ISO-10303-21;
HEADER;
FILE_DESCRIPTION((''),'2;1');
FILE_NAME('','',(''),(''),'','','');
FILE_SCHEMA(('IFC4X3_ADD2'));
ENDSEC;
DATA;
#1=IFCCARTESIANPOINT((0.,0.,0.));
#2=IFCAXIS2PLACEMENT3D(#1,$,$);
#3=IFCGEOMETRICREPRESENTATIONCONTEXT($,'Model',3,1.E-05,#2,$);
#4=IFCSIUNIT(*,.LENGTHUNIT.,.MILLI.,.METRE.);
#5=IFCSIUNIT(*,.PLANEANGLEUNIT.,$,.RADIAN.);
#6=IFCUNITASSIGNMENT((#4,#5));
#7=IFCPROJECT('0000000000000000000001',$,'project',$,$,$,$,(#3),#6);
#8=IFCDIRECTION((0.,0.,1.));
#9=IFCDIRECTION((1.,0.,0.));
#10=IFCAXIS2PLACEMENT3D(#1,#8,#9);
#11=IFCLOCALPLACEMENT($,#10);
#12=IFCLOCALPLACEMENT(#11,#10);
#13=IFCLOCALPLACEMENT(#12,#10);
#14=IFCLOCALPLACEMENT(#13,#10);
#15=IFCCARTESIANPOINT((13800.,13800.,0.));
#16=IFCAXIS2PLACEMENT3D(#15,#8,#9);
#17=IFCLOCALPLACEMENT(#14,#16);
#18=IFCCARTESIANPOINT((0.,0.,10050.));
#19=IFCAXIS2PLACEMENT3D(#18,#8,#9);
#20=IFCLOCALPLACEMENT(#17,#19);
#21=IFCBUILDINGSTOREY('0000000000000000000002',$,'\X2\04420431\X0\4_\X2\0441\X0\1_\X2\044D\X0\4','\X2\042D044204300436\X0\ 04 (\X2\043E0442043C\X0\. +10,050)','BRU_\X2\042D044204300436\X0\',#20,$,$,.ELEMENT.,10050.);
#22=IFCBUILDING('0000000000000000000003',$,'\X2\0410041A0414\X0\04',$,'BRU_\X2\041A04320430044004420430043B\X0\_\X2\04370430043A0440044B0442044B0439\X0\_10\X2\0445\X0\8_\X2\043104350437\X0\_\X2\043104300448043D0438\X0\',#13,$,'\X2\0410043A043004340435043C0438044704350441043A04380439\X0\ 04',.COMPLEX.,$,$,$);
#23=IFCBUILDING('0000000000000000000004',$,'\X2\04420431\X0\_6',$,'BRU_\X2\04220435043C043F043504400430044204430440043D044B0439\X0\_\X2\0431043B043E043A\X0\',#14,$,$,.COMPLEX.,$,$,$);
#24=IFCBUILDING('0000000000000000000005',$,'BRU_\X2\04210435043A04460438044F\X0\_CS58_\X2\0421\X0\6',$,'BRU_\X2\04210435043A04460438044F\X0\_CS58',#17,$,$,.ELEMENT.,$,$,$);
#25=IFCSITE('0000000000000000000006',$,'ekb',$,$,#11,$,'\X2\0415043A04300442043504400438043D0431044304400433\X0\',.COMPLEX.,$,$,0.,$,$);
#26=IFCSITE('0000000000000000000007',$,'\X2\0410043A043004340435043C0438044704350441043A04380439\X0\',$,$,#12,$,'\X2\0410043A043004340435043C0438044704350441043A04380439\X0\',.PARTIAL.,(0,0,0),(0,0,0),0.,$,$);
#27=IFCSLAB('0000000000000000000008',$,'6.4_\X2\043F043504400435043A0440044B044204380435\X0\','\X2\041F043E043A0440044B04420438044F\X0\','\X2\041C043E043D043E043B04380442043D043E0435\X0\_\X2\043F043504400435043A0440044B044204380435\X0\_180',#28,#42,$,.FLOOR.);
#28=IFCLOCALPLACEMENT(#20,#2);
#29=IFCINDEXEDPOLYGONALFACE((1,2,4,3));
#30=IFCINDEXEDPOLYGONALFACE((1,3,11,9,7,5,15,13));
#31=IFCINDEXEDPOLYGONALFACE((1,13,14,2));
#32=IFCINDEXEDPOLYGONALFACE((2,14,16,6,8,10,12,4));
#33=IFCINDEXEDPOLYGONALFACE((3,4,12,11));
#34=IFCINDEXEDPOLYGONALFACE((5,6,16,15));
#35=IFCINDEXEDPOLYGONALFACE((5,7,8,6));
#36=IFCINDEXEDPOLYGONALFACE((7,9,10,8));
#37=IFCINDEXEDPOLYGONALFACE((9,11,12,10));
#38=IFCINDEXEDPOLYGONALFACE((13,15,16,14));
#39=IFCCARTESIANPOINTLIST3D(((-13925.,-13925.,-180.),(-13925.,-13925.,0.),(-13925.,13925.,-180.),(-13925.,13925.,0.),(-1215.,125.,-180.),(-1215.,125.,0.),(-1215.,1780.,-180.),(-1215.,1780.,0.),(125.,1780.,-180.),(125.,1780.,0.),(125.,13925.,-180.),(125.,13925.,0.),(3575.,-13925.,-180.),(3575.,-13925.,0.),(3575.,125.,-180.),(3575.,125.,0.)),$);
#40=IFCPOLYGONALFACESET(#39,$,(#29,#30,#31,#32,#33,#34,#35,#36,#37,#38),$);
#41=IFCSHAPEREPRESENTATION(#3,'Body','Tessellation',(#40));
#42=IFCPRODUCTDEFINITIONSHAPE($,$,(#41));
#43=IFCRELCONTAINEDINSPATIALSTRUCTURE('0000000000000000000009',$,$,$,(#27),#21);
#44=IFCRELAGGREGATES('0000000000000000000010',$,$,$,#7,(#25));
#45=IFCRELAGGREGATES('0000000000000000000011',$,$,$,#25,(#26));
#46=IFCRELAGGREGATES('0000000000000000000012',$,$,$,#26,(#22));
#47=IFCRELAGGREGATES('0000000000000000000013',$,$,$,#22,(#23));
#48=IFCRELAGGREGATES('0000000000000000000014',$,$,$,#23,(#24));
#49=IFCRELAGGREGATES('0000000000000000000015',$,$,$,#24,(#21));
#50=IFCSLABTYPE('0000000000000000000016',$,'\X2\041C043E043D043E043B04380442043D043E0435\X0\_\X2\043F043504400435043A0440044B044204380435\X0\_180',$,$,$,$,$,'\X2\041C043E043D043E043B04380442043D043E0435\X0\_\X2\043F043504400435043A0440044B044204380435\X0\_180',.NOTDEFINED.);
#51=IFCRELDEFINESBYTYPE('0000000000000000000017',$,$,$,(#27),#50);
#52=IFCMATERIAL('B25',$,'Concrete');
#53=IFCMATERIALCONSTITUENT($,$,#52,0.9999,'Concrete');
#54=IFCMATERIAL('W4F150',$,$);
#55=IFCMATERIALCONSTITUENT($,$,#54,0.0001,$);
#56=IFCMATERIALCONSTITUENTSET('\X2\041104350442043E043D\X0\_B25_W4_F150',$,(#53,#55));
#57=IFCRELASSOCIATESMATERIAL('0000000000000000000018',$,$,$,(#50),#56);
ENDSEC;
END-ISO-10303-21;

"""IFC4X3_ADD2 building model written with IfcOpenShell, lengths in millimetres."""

from ifc_helpers import new_model, si_unit, frame, origin, origin_with_axes, place, context, project, spatial, polyline, outline, extrude, material, constituent, constituent_set, type_object, element, save


model = new_model("IFC4X3_ADD2")

# Units and contexts
model_context = context("Model", 3, precision=1e-05, world=origin())
ifc_project = project(units=[si_unit("LENGTHUNIT", "METRE", prefix="MILLI"), si_unit("PLANEANGLEUNIT", "RADIAN")], contexts=[model_context])

# Sites, buildings, storey
site_1_placement = place(None, origin_with_axes())
site_1 = spatial("IfcSite", under=ifc_project, at=site_1_placement, Name="ekb", LongName="Екатеринбург", CompositionType="COMPLEX", RefElevation=0.0)
site_2_placement = place(site_1_placement, origin_with_axes())
site_2 = spatial("IfcSite", under=site_1, at=site_2_placement, Name="Академический", LongName="Академический", CompositionType="PARTIAL", RefLatitude=(0, 0, 0), RefLongitude=(0, 0, 0), RefElevation=0.0)
building_1_placement = place(site_2_placement, origin_with_axes())
building_1 = spatial("IfcBuilding", under=site_2, at=building_1_placement, Name="АКД04", ObjectType="BRU_Квартал_закрытый_10х8_без_башни", LongName="Академический 04", CompositionType="COMPLEX")
building_2_placement = place(building_1_placement, origin_with_axes())
building_2 = spatial("IfcBuilding", under=building_1, at=building_2_placement, Name="тб_6", ObjectType="BRU_Температурный_блок", CompositionType="COMPLEX")
building_3_placement = place(building_2_placement, frame((13800.0, 13800.0, 0.0), z_axis=(0.0, 0.0, 1.0), x_axis=(1.0, 0.0, 0.0)))
building_3 = spatial("IfcBuilding", under=building_2, at=building_3_placement, Name="BRU_Секция_CS58_С6", ObjectType="BRU_Секция_CS58", CompositionType="ELEMENT")
storey_placement = place(building_3_placement, frame((0.0, 0.0, 10050.0), z_axis=(0.0, 0.0, 1.0), x_axis=(1.0, 0.0, 0.0)))
storey = spatial("IfcBuildingStorey", under=building_3, at=storey_placement, Name="тб4_с1_э4", Description="Этаж 04 (отм. +10,050)", ObjectType="BRU_Этаж", CompositionType="ELEMENT", Elevation=10050.0)

# Shared definitions
ifc_material_1 = material(Name="B25", Category="Concrete")
ifc_material_2 = material(Name="W4F150")

# Slab
ifc_constituent_1 = constituent(ifc_material_1, Category="Concrete", fraction=0.9999)
ifc_constituent_2 = constituent(ifc_material_2, fraction=0.0001)
ifc_constituent_set_1 = constituent_set(constituents=[ifc_constituent_1, ifc_constituent_2], Name="Бетон_B25_W4_F150")
slab_type = type_object("IfcSlabType", Name="Монолитное_перекрытие_180", ElementType="Монолитное_перекрытие_180", PredefinedType="NOTDEFINED", material=ifc_constituent_set_1)
slab_placement = place(storey_placement, frame((0.0, 0.0, -180.0), z_axis=(0.0, 0.0, 1.0), x_axis=(1.0, 0.0, 0.0)))
element("IfcSlab", 1, at=slab_placement, inside=storey, type_object=slab_type, Name="6.4_перекрытие", Description="Покрытия", ObjectType="Монолитное_перекрытие_180", PredefinedType="FLOOR", context=model_context, shape_type="SweptSolid", body=[
    extrude(outline(polyline([(-13925.0, -13925.0), (3575.0, -13925.0), (3575.0, 125.0), (-1215.0, 125.0), (-1215.0, 1780.0), (125.0, 1780.0), (125.0, 13925.0), (-13925.0, 13925.0), (-13925.0, -13925.0)])), origin_with_axes(), (0.0, 0.0, 1.0), 180.0),
])

save(model, "model.ifc")
